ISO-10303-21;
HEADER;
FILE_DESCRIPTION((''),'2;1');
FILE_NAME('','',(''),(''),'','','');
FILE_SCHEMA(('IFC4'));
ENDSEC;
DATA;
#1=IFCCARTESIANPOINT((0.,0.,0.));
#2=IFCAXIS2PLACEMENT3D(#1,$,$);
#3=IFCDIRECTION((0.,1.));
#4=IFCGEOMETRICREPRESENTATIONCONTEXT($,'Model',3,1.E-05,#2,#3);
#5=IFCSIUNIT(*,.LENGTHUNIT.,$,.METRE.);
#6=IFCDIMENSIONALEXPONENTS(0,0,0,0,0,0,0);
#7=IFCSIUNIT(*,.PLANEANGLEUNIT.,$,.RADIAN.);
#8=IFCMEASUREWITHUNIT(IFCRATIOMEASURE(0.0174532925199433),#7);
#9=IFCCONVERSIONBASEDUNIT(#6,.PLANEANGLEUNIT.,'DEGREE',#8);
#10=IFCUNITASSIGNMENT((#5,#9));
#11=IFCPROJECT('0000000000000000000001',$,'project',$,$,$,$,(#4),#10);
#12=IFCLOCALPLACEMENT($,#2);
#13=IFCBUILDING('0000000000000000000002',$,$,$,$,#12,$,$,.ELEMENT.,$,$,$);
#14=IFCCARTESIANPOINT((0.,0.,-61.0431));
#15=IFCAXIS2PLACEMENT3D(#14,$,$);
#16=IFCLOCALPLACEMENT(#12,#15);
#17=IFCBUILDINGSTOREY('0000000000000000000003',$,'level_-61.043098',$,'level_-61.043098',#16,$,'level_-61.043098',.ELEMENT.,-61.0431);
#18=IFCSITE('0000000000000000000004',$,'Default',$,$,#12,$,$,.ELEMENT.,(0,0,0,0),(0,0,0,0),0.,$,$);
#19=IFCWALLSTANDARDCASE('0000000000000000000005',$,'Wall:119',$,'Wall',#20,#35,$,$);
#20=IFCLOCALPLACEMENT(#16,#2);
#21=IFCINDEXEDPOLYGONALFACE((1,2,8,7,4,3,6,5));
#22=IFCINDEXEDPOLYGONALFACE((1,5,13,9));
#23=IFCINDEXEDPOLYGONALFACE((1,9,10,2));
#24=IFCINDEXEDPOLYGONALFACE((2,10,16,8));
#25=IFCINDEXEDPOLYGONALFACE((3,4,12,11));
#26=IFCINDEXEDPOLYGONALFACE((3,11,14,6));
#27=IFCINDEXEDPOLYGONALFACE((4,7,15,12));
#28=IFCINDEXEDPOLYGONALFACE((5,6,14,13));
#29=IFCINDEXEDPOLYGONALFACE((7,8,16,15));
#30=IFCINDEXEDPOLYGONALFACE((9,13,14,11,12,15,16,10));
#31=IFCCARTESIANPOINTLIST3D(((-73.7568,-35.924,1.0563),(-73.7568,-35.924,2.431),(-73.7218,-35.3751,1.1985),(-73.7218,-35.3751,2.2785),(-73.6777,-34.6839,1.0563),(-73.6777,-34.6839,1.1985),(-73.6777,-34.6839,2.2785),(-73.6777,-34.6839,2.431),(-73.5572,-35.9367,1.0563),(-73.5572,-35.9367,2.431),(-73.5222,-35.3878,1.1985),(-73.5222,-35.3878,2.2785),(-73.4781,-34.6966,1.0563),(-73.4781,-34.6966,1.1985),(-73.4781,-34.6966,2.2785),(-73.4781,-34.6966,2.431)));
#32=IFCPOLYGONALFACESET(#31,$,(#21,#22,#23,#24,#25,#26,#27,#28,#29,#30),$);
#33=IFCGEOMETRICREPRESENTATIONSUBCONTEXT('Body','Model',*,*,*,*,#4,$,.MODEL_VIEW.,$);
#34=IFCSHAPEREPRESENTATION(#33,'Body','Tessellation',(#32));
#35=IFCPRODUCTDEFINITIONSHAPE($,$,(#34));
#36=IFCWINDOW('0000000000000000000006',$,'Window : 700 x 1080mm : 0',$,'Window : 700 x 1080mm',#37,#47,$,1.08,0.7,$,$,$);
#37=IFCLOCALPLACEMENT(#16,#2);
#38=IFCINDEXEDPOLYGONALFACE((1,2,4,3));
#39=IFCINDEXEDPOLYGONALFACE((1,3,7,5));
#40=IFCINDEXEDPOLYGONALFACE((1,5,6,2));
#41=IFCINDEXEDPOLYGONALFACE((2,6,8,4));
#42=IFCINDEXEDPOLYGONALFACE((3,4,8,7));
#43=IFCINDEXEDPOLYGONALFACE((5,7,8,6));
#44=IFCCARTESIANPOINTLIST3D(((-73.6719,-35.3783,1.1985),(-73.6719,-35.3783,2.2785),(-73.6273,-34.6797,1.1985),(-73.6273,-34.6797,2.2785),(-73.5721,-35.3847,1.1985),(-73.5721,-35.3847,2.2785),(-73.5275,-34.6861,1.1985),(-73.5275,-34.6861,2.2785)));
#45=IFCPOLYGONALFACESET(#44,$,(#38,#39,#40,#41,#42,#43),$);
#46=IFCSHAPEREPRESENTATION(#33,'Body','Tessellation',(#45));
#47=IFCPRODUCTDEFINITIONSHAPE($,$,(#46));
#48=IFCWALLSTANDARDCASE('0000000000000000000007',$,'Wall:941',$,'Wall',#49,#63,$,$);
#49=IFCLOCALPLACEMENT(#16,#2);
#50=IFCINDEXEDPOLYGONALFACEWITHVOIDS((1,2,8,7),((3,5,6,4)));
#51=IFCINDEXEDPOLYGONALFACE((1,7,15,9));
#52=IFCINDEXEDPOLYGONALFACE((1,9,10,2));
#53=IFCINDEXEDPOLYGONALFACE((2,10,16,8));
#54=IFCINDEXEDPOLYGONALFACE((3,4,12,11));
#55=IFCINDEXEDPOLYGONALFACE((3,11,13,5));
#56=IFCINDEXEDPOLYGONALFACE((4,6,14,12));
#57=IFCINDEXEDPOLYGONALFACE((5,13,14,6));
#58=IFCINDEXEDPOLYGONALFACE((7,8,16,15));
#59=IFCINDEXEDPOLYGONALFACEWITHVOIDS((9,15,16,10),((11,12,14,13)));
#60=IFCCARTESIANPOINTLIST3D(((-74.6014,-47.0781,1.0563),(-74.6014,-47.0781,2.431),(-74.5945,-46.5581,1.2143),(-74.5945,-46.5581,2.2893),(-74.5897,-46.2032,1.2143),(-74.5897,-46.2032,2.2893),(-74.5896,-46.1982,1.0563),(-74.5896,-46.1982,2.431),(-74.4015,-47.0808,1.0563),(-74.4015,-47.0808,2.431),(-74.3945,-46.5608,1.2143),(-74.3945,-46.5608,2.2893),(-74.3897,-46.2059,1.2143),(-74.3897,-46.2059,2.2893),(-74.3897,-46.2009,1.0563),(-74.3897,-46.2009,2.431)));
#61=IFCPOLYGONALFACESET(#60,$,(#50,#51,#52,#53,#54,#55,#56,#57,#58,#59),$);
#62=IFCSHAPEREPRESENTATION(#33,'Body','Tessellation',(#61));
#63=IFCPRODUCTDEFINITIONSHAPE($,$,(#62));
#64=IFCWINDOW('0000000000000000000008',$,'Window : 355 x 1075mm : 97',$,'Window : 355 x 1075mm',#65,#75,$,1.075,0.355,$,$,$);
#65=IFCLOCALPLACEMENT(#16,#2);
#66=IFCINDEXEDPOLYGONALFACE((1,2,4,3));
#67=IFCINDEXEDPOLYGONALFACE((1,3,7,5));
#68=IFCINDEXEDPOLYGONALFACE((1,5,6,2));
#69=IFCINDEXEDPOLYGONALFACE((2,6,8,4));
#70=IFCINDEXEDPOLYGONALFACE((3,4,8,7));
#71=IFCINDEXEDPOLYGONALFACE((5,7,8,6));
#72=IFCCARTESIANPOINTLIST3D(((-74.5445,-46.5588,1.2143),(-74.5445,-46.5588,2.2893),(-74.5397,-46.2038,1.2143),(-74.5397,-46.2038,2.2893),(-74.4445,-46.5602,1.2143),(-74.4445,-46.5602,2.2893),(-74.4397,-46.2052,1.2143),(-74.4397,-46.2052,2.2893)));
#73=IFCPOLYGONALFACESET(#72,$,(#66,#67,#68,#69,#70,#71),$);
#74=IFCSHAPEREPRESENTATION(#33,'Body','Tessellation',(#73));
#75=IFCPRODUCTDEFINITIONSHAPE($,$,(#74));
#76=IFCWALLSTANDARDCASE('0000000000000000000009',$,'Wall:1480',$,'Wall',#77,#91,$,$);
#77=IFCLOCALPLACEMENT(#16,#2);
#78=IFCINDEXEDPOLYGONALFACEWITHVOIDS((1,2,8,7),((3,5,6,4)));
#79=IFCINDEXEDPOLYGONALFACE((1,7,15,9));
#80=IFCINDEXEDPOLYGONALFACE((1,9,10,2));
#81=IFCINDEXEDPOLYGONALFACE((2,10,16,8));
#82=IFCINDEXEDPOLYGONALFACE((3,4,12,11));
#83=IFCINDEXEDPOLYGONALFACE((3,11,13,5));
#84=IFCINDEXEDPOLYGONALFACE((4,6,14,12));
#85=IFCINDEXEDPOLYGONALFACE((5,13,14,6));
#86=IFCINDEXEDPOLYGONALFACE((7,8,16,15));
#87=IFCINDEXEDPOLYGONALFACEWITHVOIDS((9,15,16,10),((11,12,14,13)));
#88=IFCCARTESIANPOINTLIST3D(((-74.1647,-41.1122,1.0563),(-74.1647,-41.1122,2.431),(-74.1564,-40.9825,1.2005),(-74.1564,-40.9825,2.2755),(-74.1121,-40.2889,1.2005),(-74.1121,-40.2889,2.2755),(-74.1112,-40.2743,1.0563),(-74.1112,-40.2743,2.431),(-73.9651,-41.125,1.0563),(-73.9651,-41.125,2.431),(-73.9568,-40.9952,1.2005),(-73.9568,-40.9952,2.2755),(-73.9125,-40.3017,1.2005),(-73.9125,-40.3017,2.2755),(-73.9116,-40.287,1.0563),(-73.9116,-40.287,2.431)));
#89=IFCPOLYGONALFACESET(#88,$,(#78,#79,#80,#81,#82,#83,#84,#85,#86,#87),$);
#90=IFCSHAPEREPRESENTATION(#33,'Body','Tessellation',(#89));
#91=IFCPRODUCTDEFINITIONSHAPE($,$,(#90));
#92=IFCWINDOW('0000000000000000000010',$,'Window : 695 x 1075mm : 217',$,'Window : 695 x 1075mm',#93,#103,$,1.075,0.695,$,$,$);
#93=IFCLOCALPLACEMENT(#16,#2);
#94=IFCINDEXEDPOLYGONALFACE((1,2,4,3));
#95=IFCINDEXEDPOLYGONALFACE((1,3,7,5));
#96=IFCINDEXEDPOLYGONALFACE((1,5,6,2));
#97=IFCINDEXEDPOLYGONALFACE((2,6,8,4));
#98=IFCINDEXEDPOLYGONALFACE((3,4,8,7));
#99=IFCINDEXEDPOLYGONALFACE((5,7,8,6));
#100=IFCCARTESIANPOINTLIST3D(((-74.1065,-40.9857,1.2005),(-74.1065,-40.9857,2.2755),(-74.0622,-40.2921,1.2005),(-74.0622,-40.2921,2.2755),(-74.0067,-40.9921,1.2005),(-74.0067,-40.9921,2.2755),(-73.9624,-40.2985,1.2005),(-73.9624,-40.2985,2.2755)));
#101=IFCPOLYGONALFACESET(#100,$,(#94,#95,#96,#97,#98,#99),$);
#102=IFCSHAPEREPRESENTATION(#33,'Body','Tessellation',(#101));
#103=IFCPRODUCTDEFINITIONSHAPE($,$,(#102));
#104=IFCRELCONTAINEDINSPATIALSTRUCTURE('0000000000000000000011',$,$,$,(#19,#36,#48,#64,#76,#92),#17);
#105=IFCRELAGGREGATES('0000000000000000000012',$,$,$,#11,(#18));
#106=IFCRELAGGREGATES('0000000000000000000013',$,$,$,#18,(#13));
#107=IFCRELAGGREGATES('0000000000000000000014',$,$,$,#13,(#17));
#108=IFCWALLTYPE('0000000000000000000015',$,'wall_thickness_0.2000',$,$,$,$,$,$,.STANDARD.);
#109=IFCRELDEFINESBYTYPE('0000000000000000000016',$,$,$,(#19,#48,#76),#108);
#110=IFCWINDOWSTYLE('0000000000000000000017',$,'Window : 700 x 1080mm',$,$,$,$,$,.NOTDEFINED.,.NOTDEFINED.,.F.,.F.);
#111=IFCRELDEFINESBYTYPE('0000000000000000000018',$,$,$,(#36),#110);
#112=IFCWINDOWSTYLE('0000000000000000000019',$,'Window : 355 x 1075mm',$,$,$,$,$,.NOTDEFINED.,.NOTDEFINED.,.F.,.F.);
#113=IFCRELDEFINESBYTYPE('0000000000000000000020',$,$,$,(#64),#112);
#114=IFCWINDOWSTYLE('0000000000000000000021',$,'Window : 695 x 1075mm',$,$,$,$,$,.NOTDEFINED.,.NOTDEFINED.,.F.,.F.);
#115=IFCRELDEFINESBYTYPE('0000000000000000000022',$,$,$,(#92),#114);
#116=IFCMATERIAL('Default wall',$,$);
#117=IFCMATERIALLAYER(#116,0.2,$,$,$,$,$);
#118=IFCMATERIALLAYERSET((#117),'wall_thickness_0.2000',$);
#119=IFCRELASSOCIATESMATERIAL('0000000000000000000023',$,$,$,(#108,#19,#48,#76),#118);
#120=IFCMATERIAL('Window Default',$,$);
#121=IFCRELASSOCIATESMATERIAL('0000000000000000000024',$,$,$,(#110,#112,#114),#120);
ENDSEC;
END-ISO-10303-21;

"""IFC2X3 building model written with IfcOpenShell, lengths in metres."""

from ifc_helpers import new_model, entity, si_unit, converted_unit, direction, frame, frame_2d, origin, origin_2d_with_axis, place, context, subcontext, project, spatial, polyline, rectangle, outline, extrude, source, transform, mapped, material, layer, layer_set, layer_usage, type_object, type_shapes, element, fill, save


model = new_model("IFC2X3")

# Units and contexts
model_context = context("Model", 3, precision=1e-05, world=origin(), true_north=direction((0.0, 1.0)))
body_context = subcontext(model_context, "Body", "Model", "MODEL_VIEW")
ifc_project = project(units=[si_unit("LENGTHUNIT", "METRE"), converted_unit("PLANEANGLEUNIT", "DEGREE", entity("IfcRatioMeasure", 0.0174532925199433), si_unit("PLANEANGLEUNIT", "RADIAN"), dimensions=[0, 0, 0, 0, 0, 0, 0])], contexts=[model_context])

# Site, building, storey
placement_1 = place(None, origin())
site = spatial("IfcSite", under=ifc_project, at=placement_1, Name="Default", CompositionType="ELEMENT", RefLatitude=(0, 0, 0, 0), RefLongitude=(0, 0, 0, 0), RefElevation=0.0)
building = spatial("IfcBuilding", under=site, at=placement_1, CompositionType="ELEMENT")
storey_placement = place(placement_1, frame((0.0, 0.0, -61.0431)))
storey = spatial("IfcBuildingStorey", under=building, at=storey_placement, Name="level_-61.043098", ObjectType="level_-61.043098", LongName="level_-61.043098", CompositionType="ELEMENT", Elevation=-61.0431)

# Walls, openings, windows
ifc_material_1 = material(Name="Default wall")
ifc_layer = layer(ifc_material_1, 0.2)
ifc_layer_set = layer_set([ifc_layer], Name="wall_thickness_0.2000")
ifc_layer_usage = layer_usage(ifc_layer_set, "AXIS2", "POSITIVE", -0.1)
wall_type = type_object("IfcWallType", Name="wall_thickness_0.2000", PredefinedType="STANDARD", material=ifc_layer_set)
placement_2 = place(placement_1, frame((0.0, 0.0, -59.9868)))
wall_1_placement = place(placement_2, frame((-73.5779, -34.6903, 0.0), z_axis=(0.0, 0.0, 1.0), x_axis=(-0.063707, -0.997969, 0.0)))
wall_1 = element("IfcWallStandardCase", 1, at=wall_1_placement, inside=storey, type_object=wall_type, material=ifc_layer_usage, Name="Wall:119", ObjectType="Wall", context=body_context, shape_type="SweptSolid", body=[
    extrude(outline(polyline([(1.2426, -0.1), (1.2426, 0.1), (0.0, 0.1), (0.0, -0.1), (1.2426, -0.1)])), origin(), (0.0, 0.0, 1.0), 1.3747),
])
opening_1_placement = place(wall_1_placement, frame((-0.0074, -0.1, 0.1421)))
opening_1 = element("IfcOpeningElement", 2, at=opening_1_placement, cuts=wall_1, ObjectType="Opening", context=body_context, shape_type="SweptSolid", body=[
    extrude(rectangle(XDim=0.7, YDim=1.08, at=frame_2d((0.54, 0.35), x_axis=(0.0, 1.0))), frame((0.0, 0.0, 0.0), z_axis=(0.0, 1.0, 0.0), x_axis=(0.0, 0.0, 1.0)), (0.0, 0.0, 1.0), 0.2),
])
ifc_material_2 = material(Name="Window Default")
window_style_1 = type_object("IfcWindowStyle", Name="Window : 700 x 1080mm", ConstructionType="NOTDEFINED", OperationType="NOTDEFINED", ParameterTakesPrecedence=False, Sizeable=False, material=ifc_material_2)
shared_shape_1 = source(origin(), body_context, "Body", "SweptSolid", [
    extrude(rectangle(XDim=0.1, YDim=0.7, at=origin_2d_with_axis()), frame((0.35, 0.1, 0.0), z_axis=(0.0, 0.0, 1.0), x_axis=(0.0, 1.0, 0.0)), (0.0, 0.0, 1.0), 1.08),
])
type_shapes(window_style_1, [shared_shape_1])
window_1_placement = place(opening_1_placement, origin())
window_1 = element("IfcWindow", 3, at=window_1_placement, inside=storey, type_object=window_style_1, Name="Window : 700 x 1080mm : 0", ObjectType="Window : 700 x 1080mm", OverallHeight=1.08, OverallWidth=0.7, context=body_context, shape_type="MappedRepresentation", body=[
    mapped(shared_shape_1, transform((0.0, 0.0, 0.0), scale=1.0)),
])
fill(opening_1, window_1)
placement_3 = place(placement_1, frame((0.0, 0.0, -59.9868)))
wall_2_placement = place(placement_3, frame((-74.4896, -46.1995, 0.0), z_axis=(0.0, 0.0, 1.0), x_axis=(-0.013403, -0.99991, 0.0)))
wall_2 = element("IfcWallStandardCase", 4, at=wall_2_placement, inside=storey, type_object=wall_type, material=ifc_layer_usage, Name="Wall:941", ObjectType="Wall", context=body_context, shape_type="SweptSolid", body=[
    extrude(outline(polyline([(0.88, -0.1), (0.88, 0.1), (0.0, 0.1), (0.0, -0.1), (0.88, -0.1)])), origin(), (0.0, 0.0, 1.0), 1.3747),
])
opening_2_placement = place(wall_2_placement, frame((0.005, -0.1, 0.158)))
opening_2 = element("IfcOpeningElement", 5, at=opening_2_placement, cuts=wall_2, ObjectType="Opening", context=body_context, shape_type="SweptSolid", body=[
    extrude(rectangle(XDim=0.355, YDim=1.075, at=frame_2d((0.5375, 0.1775), x_axis=(0.0, 1.0))), frame((0.0, 0.0, 0.0), z_axis=(0.0, 1.0, 0.0), x_axis=(0.0, 0.0, 1.0)), (0.0, 0.0, 1.0), 0.2),
])
window_style_2 = type_object("IfcWindowStyle", Name="Window : 355 x 1075mm", ConstructionType="NOTDEFINED", OperationType="NOTDEFINED", ParameterTakesPrecedence=False, Sizeable=False, material=ifc_material_2)
shared_shape_2 = source(origin(), body_context, "Body", "SweptSolid", [
    extrude(rectangle(XDim=0.1, YDim=0.355, at=origin_2d_with_axis()), frame((0.1775, 0.1, 0.0), z_axis=(0.0, 0.0, 1.0), x_axis=(0.0, 1.0, 0.0)), (0.0, 0.0, 1.0), 1.075),
])
type_shapes(window_style_2, [shared_shape_2])
window_2_placement = place(opening_2_placement, origin())
window_2 = element("IfcWindow", 6, at=window_2_placement, inside=storey, type_object=window_style_2, Name="Window : 355 x 1075mm : 97", ObjectType="Window : 355 x 1075mm", OverallHeight=1.075, OverallWidth=0.355, context=body_context, shape_type="MappedRepresentation", body=[
    mapped(shared_shape_2, transform((0.0, 0.0, 0.0), scale=1.0)),
])
fill(opening_2, window_2)

# Wall, opening, window
placement_4 = place(placement_1, frame((0.0, 0.0, -59.9868)))
wall_3_placement = place(placement_4, frame((-74.0114, -40.2806, 0.0), z_axis=(0.0, 0.0, 1.0), x_axis=(-0.063712, -0.997968, 0.0)))
wall_3 = element("IfcWallStandardCase", 7, at=wall_3_placement, inside=storey, type_object=wall_type, material=ifc_layer_usage, Name="Wall:1480", ObjectType="Wall", context=body_context, shape_type="SweptSolid", body=[
    extrude(outline(polyline([(0.8397, -0.1), (0.8397, 0.1), (0.0, 0.1), (0.0, -0.1), (0.8397, -0.1)])), origin(), (0.0, 0.0, 1.0), 1.3747),
])
opening_3_placement = place(wall_3_placement, frame((0.0147, -0.1, 0.1441)))
opening_3 = element("IfcOpeningElement", 8, at=opening_3_placement, cuts=wall_3, ObjectType="Opening", context=body_context, shape_type="SweptSolid", body=[
    extrude(rectangle(XDim=0.695, YDim=1.075, at=frame_2d((0.5375, 0.3475), x_axis=(0.0, 1.0))), frame((0.0, 0.0, 0.0), z_axis=(0.0, 1.0, 0.0), x_axis=(0.0, 0.0, 1.0)), (0.0, 0.0, 1.0), 0.2),
])
window_style_3 = type_object("IfcWindowStyle", Name="Window : 695 x 1075mm", ConstructionType="NOTDEFINED", OperationType="NOTDEFINED", ParameterTakesPrecedence=False, Sizeable=False, material=ifc_material_2)
shared_shape_3 = source(origin(), body_context, "Body", "SweptSolid", [
    extrude(rectangle(XDim=0.1, YDim=0.695, at=origin_2d_with_axis()), frame((0.3475, 0.1, 0.0), z_axis=(0.0, 0.0, 1.0), x_axis=(0.0, 1.0, 0.0)), (0.0, 0.0, 1.0), 1.075),
])
type_shapes(window_style_3, [shared_shape_3])
window_3_placement = place(opening_3_placement, origin())
window_3 = element("IfcWindow", 9, at=window_3_placement, inside=storey, type_object=window_style_3, Name="Window : 695 x 1075mm : 217", ObjectType="Window : 695 x 1075mm", OverallHeight=1.075, OverallWidth=0.695, context=body_context, shape_type="MappedRepresentation", body=[
    mapped(shared_shape_3, transform((0.0, 0.0, 0.0), scale=1.0)),
])
fill(opening_3, window_3)

save(model, "model.ifc")
